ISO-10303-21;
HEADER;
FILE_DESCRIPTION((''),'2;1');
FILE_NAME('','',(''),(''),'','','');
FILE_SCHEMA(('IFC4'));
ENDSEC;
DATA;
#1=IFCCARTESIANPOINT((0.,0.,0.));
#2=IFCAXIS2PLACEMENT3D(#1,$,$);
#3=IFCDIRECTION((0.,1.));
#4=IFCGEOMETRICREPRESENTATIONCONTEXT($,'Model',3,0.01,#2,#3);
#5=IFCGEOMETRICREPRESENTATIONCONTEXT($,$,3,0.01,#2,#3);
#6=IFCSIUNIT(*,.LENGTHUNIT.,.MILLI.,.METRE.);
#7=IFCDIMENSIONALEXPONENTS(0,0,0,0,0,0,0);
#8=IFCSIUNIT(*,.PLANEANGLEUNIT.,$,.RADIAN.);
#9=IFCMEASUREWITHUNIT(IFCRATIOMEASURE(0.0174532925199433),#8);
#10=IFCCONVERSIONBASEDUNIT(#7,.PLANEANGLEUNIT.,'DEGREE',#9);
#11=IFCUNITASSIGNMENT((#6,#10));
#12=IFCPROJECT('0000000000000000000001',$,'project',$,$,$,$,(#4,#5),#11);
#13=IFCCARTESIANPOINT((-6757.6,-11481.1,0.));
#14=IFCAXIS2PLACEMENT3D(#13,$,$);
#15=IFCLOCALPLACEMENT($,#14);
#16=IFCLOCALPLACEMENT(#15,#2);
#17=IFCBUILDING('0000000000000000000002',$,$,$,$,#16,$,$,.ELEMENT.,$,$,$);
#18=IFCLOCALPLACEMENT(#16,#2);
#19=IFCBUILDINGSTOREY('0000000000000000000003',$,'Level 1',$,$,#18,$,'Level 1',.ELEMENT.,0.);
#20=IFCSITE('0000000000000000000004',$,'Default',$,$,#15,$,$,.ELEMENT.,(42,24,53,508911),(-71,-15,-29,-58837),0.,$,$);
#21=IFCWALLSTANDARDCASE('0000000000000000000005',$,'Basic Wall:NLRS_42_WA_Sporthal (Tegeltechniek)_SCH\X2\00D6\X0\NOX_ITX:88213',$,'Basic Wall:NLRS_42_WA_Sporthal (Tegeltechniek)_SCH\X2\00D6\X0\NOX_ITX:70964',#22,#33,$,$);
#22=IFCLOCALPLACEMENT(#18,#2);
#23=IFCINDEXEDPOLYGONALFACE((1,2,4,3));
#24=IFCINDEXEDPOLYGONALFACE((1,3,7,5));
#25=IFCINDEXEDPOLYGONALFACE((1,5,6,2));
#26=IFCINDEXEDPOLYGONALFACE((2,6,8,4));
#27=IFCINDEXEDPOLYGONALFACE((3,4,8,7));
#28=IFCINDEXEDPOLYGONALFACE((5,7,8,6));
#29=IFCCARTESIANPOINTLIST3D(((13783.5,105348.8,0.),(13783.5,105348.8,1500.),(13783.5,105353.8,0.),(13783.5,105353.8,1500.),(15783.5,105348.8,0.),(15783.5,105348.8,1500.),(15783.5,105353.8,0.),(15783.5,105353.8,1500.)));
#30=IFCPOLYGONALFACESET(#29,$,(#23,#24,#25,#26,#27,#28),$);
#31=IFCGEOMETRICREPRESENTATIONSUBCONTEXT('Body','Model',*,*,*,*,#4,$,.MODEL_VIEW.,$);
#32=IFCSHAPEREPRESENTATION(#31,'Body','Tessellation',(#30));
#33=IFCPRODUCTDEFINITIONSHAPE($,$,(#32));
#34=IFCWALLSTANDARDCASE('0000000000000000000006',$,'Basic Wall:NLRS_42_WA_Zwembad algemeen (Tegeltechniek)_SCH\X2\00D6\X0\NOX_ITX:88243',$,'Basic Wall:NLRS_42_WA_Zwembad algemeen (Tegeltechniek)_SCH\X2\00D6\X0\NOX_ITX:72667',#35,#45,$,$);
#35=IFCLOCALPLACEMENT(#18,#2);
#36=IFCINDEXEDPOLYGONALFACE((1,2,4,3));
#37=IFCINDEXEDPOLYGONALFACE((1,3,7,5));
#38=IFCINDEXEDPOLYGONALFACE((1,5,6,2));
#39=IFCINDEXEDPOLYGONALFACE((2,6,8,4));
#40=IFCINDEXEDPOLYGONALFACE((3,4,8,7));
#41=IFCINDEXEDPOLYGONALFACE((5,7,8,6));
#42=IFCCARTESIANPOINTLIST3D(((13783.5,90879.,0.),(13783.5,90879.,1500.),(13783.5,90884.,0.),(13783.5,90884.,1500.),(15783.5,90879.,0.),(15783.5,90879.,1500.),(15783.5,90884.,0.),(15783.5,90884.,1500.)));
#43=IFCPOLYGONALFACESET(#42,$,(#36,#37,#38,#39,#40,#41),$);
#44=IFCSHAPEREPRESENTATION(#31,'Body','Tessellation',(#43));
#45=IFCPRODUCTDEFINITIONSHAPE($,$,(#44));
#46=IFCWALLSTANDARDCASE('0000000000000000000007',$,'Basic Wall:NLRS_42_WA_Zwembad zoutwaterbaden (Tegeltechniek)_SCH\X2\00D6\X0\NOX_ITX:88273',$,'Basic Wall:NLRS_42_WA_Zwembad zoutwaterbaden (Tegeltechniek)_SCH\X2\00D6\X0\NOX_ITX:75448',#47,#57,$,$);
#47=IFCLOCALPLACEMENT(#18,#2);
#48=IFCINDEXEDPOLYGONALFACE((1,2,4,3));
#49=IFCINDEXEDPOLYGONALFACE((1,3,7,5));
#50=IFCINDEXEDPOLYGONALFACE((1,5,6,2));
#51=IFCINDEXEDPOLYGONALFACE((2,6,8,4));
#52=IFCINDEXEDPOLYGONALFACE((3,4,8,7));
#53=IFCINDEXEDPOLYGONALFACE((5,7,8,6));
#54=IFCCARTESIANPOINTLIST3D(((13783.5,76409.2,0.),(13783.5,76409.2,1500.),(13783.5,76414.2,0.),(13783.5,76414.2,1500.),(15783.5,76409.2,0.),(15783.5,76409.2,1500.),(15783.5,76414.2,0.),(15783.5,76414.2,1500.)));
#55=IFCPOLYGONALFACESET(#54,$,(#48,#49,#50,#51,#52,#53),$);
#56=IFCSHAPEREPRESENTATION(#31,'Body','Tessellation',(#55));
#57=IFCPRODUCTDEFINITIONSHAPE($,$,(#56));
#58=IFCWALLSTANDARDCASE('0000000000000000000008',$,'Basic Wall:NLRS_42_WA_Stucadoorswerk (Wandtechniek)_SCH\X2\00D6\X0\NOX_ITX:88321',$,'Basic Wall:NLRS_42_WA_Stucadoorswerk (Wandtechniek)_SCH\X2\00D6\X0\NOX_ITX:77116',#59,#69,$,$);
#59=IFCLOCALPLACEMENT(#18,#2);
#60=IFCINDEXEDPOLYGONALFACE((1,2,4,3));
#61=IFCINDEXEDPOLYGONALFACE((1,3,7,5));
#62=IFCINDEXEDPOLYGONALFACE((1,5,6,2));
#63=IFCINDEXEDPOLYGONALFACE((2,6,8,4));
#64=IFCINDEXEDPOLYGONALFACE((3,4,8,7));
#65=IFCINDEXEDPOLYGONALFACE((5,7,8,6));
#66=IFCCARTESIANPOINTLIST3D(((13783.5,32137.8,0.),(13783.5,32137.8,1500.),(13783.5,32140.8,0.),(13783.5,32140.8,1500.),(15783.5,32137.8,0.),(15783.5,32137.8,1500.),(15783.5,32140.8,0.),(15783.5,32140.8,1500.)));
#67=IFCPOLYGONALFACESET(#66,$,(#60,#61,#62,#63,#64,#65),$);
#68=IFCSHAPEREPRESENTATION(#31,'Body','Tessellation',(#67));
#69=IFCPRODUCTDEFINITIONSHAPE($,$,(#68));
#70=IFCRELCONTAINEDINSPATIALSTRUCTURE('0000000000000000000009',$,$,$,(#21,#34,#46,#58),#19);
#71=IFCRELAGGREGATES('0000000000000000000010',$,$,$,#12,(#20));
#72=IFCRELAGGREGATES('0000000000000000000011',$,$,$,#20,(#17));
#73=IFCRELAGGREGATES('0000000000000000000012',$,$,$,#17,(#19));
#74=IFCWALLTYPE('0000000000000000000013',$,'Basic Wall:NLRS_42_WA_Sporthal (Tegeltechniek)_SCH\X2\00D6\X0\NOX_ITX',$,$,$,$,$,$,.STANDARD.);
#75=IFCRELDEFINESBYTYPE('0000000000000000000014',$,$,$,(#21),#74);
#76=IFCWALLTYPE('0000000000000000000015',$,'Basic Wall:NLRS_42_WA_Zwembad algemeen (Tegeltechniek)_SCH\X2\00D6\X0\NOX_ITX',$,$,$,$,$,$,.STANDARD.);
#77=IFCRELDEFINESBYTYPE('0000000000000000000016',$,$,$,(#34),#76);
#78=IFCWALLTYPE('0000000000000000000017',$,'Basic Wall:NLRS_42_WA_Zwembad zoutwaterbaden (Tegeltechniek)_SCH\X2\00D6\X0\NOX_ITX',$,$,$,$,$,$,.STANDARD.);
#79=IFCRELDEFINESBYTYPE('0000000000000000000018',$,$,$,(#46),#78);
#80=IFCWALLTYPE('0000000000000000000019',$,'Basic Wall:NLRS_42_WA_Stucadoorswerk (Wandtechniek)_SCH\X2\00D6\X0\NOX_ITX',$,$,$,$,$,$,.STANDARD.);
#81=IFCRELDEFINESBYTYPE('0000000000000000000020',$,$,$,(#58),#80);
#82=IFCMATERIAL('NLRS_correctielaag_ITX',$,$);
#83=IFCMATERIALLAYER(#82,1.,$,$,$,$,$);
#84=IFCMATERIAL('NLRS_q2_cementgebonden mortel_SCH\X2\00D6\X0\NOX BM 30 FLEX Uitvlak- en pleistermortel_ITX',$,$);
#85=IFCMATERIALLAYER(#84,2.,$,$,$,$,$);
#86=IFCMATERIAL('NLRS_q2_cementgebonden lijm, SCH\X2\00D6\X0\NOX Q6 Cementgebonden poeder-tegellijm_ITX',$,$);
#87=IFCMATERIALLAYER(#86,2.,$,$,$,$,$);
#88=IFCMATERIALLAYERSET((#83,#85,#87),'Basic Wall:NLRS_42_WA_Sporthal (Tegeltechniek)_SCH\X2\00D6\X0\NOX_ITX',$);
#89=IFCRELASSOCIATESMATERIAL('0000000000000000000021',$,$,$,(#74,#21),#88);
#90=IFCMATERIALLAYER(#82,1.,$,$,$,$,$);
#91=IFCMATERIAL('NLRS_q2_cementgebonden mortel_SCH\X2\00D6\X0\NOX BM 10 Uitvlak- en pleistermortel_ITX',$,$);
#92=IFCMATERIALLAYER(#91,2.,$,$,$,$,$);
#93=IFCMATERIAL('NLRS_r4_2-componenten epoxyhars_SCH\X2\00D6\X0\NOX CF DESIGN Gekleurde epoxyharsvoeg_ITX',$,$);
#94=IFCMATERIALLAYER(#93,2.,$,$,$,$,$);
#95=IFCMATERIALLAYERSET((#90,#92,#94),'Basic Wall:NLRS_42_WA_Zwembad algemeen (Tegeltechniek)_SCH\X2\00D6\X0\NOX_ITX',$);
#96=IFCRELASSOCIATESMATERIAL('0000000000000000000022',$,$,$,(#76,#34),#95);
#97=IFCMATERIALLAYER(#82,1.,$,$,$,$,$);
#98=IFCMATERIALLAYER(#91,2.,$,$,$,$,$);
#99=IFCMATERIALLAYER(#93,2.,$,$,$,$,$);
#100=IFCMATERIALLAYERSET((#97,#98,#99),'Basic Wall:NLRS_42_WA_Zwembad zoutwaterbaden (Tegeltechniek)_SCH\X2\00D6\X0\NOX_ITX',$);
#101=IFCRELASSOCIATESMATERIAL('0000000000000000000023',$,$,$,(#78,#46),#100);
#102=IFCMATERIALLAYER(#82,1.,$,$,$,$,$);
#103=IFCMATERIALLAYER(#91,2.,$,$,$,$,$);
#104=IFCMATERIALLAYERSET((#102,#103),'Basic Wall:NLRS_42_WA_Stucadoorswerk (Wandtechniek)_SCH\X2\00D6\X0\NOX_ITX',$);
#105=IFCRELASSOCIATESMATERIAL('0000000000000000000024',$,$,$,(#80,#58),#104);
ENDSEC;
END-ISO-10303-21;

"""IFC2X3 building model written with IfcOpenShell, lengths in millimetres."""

from ifc_helpers import new_model, entity, si_unit, converted_unit, direction, frame, frame_2d, origin, place, context, subcontext, project, spatial, rectangle, extrude, material, layer, layer_set, layer_usage, type_object, element, save


model = new_model("IFC2X3")

# Units and contexts
model_context = context("Model", 3, precision=0.01, world=origin(), true_north=direction((0.0, 1.0)))
context_of_model = context(None, 3, precision=0.01, world=origin(), true_north=direction((0.0, 1.0)))
body_context = subcontext(model_context, "Body", "Model", "MODEL_VIEW")
ifc_project = project(units=[si_unit("LENGTHUNIT", "METRE", prefix="MILLI"), converted_unit("PLANEANGLEUNIT", "DEGREE", entity("IfcRatioMeasure", 0.0174532925199433), si_unit("PLANEANGLEUNIT", "RADIAN"), dimensions=[0, 0, 0, 0, 0, 0, 0])], contexts=[model_context, context_of_model])

# Site, building, storey
site_placement = place(None, frame((-6757.6, -11481.1, 0.0)))
site = spatial("IfcSite", under=ifc_project, at=site_placement, Name="Default", CompositionType="ELEMENT", RefLatitude=(42, 24, 53, 508911), RefLongitude=(-71, -15, -29, -58837), RefElevation=0.0)
building_placement = place(site_placement, origin())
building = spatial("IfcBuilding", under=site, at=building_placement, CompositionType="ELEMENT")
storey_placement = place(building_placement, origin())
storey = spatial("IfcBuildingStorey", under=building, at=storey_placement, Name="Level 1", LongName="Level 1", CompositionType="ELEMENT", Elevation=0.0)

# Shared definitions
ifc_material_1 = material(Name="NLRS_q2_cementgebonden lijm, SCHÖNOX Q6 Cementgebonden poeder-tegellijm_ITX")
ifc_material_2 = material(Name="NLRS_q2_cementgebonden mortel_SCHÖNOX BM 30 FLEX Uitvlak- en pleistermortel_ITX")
ifc_material_3 = material(Name="NLRS_r4_2-componenten epoxyhars_SCHÖNOX CF DESIGN Gekleurde epoxyharsvoeg_ITX")

# Walls
ifc_material_4 = material(Name="NLRS_correctielaag_ITX")
ifc_layer_1 = layer(ifc_material_4, 1.0)
ifc_layer_2 = layer(ifc_material_2, 2.0)
ifc_layer_3 = layer(ifc_material_1, 2.0)
ifc_layer_set_1 = layer_set([ifc_layer_1, ifc_layer_2, ifc_layer_3], Name="Basic Wall:NLRS_42_WA_Sporthal (Tegeltechniek)_SCHÖNOX_ITX")
ifc_layer_usage_1 = layer_usage(ifc_layer_set_1, "AXIS2", "POSITIVE", -2.5)
wall_type_1 = type_object("IfcWallType", Name="Basic Wall:NLRS_42_WA_Sporthal (Tegeltechniek)_SCHÖNOX_ITX", PredefinedType="STANDARD", material=ifc_layer_set_1)
wall_1_placement = place(storey_placement, frame((13783.5, 105351.3, 0.0)))
element("IfcWallStandardCase", 1, at=wall_1_placement, inside=storey, type_object=wall_type_1, material=ifc_layer_usage_1, Name="Basic Wall:NLRS_42_WA_Sporthal (Tegeltechniek)_SCHÖNOX_ITX:88213", ObjectType="Basic Wall:NLRS_42_WA_Sporthal (Tegeltechniek)_SCHÖNOX_ITX:70964", context=body_context, shape_type="SweptSolid", body=[
    extrude(rectangle(XDim=2000.0, YDim=5.0, at=frame_2d((1000.0, 0.0), x_axis=(-1.0, 0.0))), origin(), (0.0, 0.0, 1.0), 1500.0),
])
ifc_layer_4 = layer(ifc_material_4, 1.0)
ifc_material_5 = material(Name="NLRS_q2_cementgebonden mortel_SCHÖNOX BM 10 Uitvlak- en pleistermortel_ITX")
ifc_layer_5 = layer(ifc_material_5, 2.0)
ifc_layer_6 = layer(ifc_material_3, 2.0)
ifc_layer_set_2 = layer_set([ifc_layer_4, ifc_layer_5, ifc_layer_6], Name="Basic Wall:NLRS_42_WA_Zwembad algemeen (Tegeltechniek)_SCHÖNOX_ITX")
ifc_layer_usage_2 = layer_usage(ifc_layer_set_2, "AXIS2", "POSITIVE", -2.5)
wall_type_2 = type_object("IfcWallType", Name="Basic Wall:NLRS_42_WA_Zwembad algemeen (Tegeltechniek)_SCHÖNOX_ITX", PredefinedType="STANDARD", material=ifc_layer_set_2)
wall_2_placement = place(storey_placement, frame((13783.5, 90881.5, 0.0)))
element("IfcWallStandardCase", 2, at=wall_2_placement, inside=storey, type_object=wall_type_2, material=ifc_layer_usage_2, Name="Basic Wall:NLRS_42_WA_Zwembad algemeen (Tegeltechniek)_SCHÖNOX_ITX:88243", ObjectType="Basic Wall:NLRS_42_WA_Zwembad algemeen (Tegeltechniek)_SCHÖNOX_ITX:72667", context=body_context, shape_type="SweptSolid", body=[
    extrude(rectangle(XDim=2000.0, YDim=5.0, at=frame_2d((1000.0, 0.0), x_axis=(-1.0, 0.0))), origin(), (0.0, 0.0, 1.0), 1500.0),
])
ifc_layer_7 = layer(ifc_material_4, 1.0)
ifc_layer_8 = layer(ifc_material_5, 2.0)
ifc_layer_9 = layer(ifc_material_3, 2.0)
ifc_layer_set_3 = layer_set([ifc_layer_7, ifc_layer_8, ifc_layer_9], Name="Basic Wall:NLRS_42_WA_Zwembad zoutwaterbaden (Tegeltechniek)_SCHÖNOX_ITX")
ifc_layer_usage_3 = layer_usage(ifc_layer_set_3, "AXIS2", "POSITIVE", -2.5)
wall_type_3 = type_object("IfcWallType", Name="Basic Wall:NLRS_42_WA_Zwembad zoutwaterbaden (Tegeltechniek)_SCHÖNOX_ITX", PredefinedType="STANDARD", material=ifc_layer_set_3)
wall_3_placement = place(storey_placement, frame((13783.5, 76411.7, 0.0)))
element("IfcWallStandardCase", 3, at=wall_3_placement, inside=storey, type_object=wall_type_3, material=ifc_layer_usage_3, Name="Basic Wall:NLRS_42_WA_Zwembad zoutwaterbaden (Tegeltechniek)_SCHÖNOX_ITX:88273", ObjectType="Basic Wall:NLRS_42_WA_Zwembad zoutwaterbaden (Tegeltechniek)_SCHÖNOX_ITX:75448", context=body_context, shape_type="SweptSolid", body=[
    extrude(rectangle(XDim=2000.0, YDim=5.0, at=frame_2d((1000.0, 0.0), x_axis=(-1.0, 0.0))), origin(), (0.0, 0.0, 1.0), 1500.0),
])
ifc_layer_10 = layer(ifc_material_4, 1.0)
ifc_layer_11 = layer(ifc_material_5, 2.0)
ifc_layer_set_4 = layer_set([ifc_layer_10, ifc_layer_11], Name="Basic Wall:NLRS_42_WA_Stucadoorswerk (Wandtechniek)_SCHÖNOX_ITX")
ifc_layer_usage_4 = layer_usage(ifc_layer_set_4, "AXIS2", "POSITIVE", -1.5)
wall_type_4 = type_object("IfcWallType", Name="Basic Wall:NLRS_42_WA_Stucadoorswerk (Wandtechniek)_SCHÖNOX_ITX", PredefinedType="STANDARD", material=ifc_layer_set_4)
wall_4_placement = place(storey_placement, frame((13783.5, 32139.3, 0.0)))
element("IfcWallStandardCase", 4, at=wall_4_placement, inside=storey, type_object=wall_type_4, material=ifc_layer_usage_4, Name="Basic Wall:NLRS_42_WA_Stucadoorswerk (Wandtechniek)_SCHÖNOX_ITX:88321", ObjectType="Basic Wall:NLRS_42_WA_Stucadoorswerk (Wandtechniek)_SCHÖNOX_ITX:77116", context=body_context, shape_type="SweptSolid", body=[
    extrude(rectangle(XDim=2000.0, YDim=3.0, at=frame_2d((1000.0, 0.0), x_axis=(-1.0, 0.0))), origin(), (0.0, 0.0, 1.0), 1500.0),
])

save(model, "model.ifc")
